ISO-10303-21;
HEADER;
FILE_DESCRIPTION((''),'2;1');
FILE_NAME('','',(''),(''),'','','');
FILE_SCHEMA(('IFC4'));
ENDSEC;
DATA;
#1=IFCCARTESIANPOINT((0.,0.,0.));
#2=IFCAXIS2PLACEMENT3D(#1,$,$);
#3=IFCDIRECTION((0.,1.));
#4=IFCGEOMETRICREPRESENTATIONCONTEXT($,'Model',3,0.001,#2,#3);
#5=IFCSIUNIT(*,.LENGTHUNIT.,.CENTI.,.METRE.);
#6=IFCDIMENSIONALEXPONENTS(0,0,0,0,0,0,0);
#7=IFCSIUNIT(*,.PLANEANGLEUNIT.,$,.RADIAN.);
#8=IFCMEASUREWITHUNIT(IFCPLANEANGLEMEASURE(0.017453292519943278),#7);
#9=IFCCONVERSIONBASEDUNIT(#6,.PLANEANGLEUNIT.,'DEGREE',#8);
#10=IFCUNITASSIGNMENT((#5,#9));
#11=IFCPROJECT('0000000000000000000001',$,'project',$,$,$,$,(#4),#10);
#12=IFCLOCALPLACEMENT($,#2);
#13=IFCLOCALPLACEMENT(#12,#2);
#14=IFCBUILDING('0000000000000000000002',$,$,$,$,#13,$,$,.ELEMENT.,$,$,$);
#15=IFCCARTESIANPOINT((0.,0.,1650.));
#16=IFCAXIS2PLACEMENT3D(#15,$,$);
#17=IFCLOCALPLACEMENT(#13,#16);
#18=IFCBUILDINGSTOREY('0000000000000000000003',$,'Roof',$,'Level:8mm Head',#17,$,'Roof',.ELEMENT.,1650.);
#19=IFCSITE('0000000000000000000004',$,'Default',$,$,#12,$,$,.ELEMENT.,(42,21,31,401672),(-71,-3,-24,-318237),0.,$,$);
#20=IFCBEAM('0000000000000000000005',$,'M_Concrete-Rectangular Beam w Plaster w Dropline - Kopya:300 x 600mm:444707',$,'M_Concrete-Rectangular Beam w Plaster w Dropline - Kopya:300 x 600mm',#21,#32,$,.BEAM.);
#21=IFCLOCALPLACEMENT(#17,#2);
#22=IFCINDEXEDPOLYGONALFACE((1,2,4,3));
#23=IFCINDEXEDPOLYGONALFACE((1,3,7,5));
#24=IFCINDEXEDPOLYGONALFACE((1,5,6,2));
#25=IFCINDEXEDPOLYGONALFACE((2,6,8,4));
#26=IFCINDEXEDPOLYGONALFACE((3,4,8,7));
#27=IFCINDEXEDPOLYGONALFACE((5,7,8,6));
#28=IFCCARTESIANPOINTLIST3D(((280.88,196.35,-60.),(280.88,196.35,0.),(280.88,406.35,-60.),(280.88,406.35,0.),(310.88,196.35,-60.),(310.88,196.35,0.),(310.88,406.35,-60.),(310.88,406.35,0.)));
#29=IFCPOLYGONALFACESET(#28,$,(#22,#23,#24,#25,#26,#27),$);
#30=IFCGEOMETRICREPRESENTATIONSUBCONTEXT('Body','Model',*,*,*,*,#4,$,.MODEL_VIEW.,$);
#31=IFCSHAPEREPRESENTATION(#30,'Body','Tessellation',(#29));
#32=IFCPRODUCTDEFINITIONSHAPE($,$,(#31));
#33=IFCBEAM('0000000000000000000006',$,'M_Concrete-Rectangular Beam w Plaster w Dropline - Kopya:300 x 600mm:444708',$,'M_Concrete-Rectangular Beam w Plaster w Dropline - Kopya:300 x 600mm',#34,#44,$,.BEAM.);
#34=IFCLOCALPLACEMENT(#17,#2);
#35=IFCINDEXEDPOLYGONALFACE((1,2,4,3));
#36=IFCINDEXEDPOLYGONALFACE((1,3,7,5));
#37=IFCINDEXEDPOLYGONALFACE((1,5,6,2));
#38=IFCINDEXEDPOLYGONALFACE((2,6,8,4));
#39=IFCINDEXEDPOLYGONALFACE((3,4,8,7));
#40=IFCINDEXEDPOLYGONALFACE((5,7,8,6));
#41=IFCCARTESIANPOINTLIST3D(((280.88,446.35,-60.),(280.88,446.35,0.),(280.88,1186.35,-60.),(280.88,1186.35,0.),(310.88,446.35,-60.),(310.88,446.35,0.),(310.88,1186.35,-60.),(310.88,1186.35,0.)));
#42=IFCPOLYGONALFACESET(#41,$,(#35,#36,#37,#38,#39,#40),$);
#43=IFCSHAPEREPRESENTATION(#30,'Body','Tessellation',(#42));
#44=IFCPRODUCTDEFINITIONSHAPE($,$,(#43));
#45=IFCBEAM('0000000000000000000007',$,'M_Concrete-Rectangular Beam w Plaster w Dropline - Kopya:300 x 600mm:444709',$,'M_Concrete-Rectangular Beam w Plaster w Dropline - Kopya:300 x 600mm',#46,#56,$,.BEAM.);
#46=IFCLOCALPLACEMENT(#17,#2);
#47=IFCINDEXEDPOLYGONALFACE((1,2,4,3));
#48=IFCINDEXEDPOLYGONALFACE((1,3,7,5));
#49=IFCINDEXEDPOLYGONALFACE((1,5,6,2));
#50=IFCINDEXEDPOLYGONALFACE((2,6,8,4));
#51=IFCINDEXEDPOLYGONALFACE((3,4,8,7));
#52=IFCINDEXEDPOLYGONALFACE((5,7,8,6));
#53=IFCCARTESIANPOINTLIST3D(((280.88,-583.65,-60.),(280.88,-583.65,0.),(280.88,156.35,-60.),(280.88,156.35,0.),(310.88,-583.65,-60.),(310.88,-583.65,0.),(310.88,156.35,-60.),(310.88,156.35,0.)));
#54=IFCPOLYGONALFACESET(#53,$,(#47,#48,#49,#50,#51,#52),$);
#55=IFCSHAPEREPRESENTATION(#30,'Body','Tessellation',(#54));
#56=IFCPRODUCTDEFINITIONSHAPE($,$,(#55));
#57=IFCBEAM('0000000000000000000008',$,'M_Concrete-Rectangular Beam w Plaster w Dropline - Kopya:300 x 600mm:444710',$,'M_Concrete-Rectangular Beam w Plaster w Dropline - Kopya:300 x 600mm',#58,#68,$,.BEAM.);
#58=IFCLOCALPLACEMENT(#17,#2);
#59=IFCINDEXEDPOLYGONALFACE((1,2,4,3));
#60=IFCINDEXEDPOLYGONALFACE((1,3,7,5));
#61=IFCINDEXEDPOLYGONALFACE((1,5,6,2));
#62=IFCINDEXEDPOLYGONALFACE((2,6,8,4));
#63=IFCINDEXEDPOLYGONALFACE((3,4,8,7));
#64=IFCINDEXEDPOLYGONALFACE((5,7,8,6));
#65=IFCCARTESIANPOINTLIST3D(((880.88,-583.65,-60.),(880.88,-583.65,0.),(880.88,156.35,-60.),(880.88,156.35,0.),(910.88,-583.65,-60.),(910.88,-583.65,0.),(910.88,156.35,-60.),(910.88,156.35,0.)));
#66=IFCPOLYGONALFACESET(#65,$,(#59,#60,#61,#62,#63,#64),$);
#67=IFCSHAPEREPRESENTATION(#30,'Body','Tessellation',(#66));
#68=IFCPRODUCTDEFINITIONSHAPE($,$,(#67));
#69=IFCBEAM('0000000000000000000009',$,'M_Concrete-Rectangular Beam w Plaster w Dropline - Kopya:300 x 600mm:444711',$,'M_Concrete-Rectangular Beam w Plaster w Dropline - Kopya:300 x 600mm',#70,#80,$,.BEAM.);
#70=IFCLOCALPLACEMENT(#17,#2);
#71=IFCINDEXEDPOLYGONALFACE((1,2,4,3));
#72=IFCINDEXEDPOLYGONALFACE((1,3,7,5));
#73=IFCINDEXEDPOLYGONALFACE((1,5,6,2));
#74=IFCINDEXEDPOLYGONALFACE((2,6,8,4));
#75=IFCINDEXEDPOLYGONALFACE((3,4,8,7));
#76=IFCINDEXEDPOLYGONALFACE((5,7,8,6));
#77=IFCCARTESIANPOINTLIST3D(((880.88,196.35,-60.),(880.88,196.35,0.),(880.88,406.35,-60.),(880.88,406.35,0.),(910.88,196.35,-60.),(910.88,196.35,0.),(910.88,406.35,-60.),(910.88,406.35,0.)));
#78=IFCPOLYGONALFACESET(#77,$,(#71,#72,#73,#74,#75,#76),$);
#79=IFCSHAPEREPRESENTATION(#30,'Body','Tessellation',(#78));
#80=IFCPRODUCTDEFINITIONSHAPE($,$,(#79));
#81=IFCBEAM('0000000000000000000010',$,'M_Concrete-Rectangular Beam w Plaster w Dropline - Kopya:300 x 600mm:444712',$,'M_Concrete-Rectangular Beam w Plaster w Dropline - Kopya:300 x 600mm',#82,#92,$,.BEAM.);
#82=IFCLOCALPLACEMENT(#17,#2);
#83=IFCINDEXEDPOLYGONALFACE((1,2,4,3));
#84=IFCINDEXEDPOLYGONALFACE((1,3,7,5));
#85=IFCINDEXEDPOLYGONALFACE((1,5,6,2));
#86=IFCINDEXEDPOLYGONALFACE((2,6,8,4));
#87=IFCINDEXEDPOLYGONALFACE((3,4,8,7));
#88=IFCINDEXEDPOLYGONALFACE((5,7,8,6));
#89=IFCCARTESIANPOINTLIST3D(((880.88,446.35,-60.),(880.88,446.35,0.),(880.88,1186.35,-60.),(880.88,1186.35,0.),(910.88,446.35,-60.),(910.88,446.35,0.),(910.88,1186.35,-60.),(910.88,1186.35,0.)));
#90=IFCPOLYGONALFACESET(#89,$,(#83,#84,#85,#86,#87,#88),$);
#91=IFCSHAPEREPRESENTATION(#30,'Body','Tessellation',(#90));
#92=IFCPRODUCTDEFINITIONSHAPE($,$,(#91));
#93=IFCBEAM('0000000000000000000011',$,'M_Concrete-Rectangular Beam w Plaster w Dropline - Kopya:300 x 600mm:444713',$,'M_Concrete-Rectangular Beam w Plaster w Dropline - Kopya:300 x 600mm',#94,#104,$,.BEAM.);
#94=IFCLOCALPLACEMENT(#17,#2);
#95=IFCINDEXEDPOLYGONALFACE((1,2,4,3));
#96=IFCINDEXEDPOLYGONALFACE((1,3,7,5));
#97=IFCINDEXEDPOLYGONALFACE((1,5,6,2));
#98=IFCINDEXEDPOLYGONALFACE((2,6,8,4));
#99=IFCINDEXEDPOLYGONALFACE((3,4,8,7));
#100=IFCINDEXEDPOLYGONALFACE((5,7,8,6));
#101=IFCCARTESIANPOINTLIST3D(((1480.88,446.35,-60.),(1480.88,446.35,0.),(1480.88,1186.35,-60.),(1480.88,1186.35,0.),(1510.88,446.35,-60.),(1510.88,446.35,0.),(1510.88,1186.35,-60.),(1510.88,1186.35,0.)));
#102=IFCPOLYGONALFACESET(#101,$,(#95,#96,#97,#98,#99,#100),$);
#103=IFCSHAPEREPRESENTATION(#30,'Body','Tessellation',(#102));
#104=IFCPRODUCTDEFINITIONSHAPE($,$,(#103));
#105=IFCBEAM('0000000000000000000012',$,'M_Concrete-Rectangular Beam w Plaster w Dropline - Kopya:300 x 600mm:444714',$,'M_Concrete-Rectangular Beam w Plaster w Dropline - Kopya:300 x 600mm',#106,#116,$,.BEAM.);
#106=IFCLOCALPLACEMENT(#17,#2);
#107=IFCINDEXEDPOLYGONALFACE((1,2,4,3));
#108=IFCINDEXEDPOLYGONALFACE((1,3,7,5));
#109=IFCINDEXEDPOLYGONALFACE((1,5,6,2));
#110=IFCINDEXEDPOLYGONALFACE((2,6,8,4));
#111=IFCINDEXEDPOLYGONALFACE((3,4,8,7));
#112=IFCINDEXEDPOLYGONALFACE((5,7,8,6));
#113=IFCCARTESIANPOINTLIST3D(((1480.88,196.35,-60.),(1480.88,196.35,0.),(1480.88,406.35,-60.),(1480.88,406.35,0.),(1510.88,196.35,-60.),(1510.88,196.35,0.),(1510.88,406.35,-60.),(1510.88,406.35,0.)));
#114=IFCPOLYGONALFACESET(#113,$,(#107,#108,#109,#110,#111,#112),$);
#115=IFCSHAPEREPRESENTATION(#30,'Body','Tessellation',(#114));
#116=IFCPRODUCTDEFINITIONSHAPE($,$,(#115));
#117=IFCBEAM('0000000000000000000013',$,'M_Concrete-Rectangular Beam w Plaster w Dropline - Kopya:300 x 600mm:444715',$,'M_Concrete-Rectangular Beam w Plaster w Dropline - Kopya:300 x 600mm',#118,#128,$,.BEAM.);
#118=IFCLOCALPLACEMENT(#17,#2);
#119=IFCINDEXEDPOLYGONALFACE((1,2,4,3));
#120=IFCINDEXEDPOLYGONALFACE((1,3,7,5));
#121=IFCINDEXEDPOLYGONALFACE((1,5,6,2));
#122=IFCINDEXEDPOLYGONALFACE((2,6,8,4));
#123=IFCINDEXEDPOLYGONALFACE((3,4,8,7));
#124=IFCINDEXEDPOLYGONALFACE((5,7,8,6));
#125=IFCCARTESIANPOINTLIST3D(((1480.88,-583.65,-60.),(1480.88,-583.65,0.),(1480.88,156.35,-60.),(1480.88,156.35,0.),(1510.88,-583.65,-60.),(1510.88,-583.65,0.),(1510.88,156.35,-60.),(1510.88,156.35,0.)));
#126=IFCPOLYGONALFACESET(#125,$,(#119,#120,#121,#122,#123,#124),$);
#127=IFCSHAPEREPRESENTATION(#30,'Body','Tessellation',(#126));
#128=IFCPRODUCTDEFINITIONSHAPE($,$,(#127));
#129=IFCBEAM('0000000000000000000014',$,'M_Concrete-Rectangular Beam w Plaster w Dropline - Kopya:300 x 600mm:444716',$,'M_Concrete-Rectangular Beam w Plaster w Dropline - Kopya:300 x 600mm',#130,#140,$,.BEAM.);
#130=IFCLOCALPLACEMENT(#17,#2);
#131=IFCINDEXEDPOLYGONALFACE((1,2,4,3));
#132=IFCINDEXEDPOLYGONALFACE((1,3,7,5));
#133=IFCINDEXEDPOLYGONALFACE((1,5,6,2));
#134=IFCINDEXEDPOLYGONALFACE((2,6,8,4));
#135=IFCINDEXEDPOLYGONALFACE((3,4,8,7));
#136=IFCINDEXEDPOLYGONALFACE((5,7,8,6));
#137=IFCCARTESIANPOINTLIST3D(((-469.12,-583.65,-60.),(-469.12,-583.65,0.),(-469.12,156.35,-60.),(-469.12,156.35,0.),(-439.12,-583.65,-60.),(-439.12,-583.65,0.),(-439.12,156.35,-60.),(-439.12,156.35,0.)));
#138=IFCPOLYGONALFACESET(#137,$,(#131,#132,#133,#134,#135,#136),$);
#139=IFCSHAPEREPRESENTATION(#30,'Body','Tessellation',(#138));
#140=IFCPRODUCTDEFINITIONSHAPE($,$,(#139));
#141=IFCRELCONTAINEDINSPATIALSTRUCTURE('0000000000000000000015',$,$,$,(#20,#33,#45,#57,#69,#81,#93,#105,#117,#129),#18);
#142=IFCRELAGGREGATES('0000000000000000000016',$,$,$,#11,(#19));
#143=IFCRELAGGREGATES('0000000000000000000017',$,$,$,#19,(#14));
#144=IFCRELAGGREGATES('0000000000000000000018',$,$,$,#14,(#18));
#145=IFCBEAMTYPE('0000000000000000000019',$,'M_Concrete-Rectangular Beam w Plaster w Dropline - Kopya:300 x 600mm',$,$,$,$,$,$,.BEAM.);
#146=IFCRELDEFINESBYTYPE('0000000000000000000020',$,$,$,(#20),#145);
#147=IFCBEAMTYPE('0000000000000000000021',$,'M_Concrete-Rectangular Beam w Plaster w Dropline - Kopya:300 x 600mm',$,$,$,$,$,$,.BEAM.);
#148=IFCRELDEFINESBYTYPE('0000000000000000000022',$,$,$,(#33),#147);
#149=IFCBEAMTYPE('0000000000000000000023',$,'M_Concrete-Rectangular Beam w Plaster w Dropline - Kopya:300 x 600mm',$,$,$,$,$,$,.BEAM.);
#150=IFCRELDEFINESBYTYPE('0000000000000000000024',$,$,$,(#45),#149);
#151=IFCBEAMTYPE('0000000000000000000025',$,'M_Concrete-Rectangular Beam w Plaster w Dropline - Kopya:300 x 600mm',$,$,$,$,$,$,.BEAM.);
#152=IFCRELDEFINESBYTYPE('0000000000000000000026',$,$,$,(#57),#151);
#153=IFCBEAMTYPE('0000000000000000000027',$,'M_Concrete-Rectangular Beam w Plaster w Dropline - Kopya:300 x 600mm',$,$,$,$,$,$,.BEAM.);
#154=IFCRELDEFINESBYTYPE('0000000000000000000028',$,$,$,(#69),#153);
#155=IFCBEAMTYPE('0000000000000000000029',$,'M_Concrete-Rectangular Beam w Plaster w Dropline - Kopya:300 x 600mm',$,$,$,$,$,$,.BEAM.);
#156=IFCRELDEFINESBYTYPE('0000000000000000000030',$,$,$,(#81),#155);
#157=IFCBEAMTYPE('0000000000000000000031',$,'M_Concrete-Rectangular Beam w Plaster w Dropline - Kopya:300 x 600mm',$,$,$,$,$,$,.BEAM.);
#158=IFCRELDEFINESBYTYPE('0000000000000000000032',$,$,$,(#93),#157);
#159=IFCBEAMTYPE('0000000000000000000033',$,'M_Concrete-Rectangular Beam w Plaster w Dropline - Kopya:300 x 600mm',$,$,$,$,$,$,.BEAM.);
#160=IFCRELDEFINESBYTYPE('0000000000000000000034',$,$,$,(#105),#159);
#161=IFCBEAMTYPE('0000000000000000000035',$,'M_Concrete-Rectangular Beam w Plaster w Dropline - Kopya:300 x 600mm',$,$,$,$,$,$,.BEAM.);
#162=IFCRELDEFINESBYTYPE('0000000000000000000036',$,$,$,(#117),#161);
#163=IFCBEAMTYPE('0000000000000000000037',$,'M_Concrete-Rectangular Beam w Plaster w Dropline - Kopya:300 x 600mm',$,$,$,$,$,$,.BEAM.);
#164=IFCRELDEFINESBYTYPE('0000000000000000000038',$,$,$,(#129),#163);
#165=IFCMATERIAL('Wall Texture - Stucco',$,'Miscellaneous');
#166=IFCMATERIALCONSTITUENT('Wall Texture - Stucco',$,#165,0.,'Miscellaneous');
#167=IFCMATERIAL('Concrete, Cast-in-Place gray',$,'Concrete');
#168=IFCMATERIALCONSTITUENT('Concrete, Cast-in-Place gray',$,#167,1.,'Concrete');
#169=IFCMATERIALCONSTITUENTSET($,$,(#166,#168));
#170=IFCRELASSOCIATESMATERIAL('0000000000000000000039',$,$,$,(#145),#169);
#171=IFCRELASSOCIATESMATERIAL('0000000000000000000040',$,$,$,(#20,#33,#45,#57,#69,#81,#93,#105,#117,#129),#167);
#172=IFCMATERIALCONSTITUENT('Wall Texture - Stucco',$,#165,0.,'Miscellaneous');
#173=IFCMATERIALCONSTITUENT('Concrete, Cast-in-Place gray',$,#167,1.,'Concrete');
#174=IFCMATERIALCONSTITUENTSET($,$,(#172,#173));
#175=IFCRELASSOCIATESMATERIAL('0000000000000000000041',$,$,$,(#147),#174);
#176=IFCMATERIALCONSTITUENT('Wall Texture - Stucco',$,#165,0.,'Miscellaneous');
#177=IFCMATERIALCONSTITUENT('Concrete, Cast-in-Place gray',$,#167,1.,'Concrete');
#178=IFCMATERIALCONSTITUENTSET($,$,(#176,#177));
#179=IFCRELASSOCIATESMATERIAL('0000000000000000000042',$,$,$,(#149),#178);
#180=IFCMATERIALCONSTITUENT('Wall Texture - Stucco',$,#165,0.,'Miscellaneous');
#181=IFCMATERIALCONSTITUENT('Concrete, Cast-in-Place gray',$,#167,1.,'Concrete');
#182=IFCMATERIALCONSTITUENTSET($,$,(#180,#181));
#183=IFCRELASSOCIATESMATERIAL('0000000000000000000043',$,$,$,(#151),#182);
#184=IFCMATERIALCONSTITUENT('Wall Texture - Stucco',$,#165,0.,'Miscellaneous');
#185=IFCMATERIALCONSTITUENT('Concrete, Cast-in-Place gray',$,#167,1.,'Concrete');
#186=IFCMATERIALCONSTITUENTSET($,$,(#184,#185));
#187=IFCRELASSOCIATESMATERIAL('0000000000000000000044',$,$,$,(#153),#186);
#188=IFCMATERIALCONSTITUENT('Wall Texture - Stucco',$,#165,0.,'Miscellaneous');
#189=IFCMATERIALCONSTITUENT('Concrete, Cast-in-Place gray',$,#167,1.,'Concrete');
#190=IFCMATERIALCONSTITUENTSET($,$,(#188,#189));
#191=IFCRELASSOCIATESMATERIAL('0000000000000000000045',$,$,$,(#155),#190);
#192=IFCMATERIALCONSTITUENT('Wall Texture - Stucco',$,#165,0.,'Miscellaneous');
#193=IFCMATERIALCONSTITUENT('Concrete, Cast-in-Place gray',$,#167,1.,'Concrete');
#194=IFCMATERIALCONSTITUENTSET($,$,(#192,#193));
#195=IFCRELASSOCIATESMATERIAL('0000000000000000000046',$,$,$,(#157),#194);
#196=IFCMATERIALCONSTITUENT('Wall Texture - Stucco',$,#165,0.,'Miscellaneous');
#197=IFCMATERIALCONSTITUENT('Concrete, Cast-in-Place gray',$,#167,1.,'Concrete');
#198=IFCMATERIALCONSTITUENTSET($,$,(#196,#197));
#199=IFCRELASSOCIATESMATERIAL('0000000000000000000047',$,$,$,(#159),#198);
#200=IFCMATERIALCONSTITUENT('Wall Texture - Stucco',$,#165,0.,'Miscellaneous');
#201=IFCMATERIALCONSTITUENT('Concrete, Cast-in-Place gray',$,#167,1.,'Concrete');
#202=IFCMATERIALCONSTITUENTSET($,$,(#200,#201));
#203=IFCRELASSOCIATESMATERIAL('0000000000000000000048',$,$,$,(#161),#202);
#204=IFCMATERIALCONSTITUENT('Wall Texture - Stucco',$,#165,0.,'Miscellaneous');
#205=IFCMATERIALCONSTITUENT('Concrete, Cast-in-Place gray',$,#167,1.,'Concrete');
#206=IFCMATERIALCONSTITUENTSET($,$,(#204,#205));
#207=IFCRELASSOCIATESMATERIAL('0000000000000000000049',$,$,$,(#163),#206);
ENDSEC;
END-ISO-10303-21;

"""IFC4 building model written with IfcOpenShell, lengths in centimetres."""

from ifc_helpers import new_model, entity, si_unit, converted_unit, direction, frame, origin, place, context, subcontext, project, spatial, indexed_curve, outline, extrude, source, transform, mapped, material, constituent, constituent_set, type_object, type_shapes, element, save


model = new_model("IFC4")

# Units and contexts
model_context = context("Model", 3, precision=0.001, world=origin(), true_north=direction((0.0, 1.0)))
body_context = subcontext(model_context, "Body", "Model", "MODEL_VIEW")
ifc_project = project(units=[si_unit("LENGTHUNIT", "METRE", prefix="CENTI"), converted_unit("PLANEANGLEUNIT", "DEGREE", entity("IfcPlaneAngleMeasure", 0.017453292519943278), si_unit("PLANEANGLEUNIT", "RADIAN"), dimensions=[0, 0, 0, 0, 0, 0, 0])], contexts=[model_context])

# Site, building, storey
site_placement = place(None, origin())
site = spatial("IfcSite", under=ifc_project, at=site_placement, Name="Default", CompositionType="ELEMENT", RefLatitude=(42, 21, 31, 401672), RefLongitude=(-71, -3, -24, -318237), RefElevation=0.0)
building_placement = place(site_placement, origin())
building = spatial("IfcBuilding", under=site, at=building_placement, CompositionType="ELEMENT")
storey_placement = place(building_placement, frame((0.0, 0.0, 1650.0)))
storey = spatial("IfcBuildingStorey", under=building, at=storey_placement, Name="Roof", ObjectType="Level:8mm Head", LongName="Roof", CompositionType="ELEMENT", Elevation=1650.0)

# Beams
ifc_material_1 = material(Name="Concrete, Cast-in-Place gray", Category="Concrete")
ifc_material_2 = material(Name="Wall Texture - Stucco", Category="Miscellaneous")
ifc_constituent_1 = constituent(ifc_material_2, Name="Wall Texture - Stucco", Category="Miscellaneous", fraction=0.0)
ifc_constituent_2 = constituent(ifc_material_1, Name="Concrete, Cast-in-Place gray", Category="Concrete", fraction=1.0)
ifc_constituent_set_1 = constituent_set(constituents=[ifc_constituent_1, ifc_constituent_2])
beam_type_1 = type_object("IfcBeamType", Name="M_Concrete-Rectangular Beam w Plaster w Dropline - Kopya:300 x 600mm", PredefinedType="BEAM", material=ifc_constituent_set_1)
shared_shape_1 = source(origin(), body_context, "Body", "SweptSolid", [
    extrude(outline(indexed_curve([(-15.0, -30.0), (15.0, -30.0), (15.0, 30.0), (-15.0, 30.0), (-15.0, -30.0)], self_intersect=False)), frame((295.88, 406.35, 1620.0), z_axis=(0.0, -1.0, 0.0), x_axis=(-1.0, 0.0, 0.0)), (0.0, 0.0, 1.0), 210.0),
])
type_shapes(beam_type_1, [shared_shape_1])
beam_1_placement = place(storey_placement, frame((0.0, 0.0, -1650.0)))
element("IfcBeam", 1, at=beam_1_placement, inside=storey, type_object=beam_type_1, material=ifc_material_1, Name="M_Concrete-Rectangular Beam w Plaster w Dropline - Kopya:300 x 600mm:444707", ObjectType="M_Concrete-Rectangular Beam w Plaster w Dropline - Kopya:300 x 600mm", PredefinedType="BEAM", context=body_context, shape_type="MappedRepresentation", body=[
    mapped(shared_shape_1, transform((0.0, 0.0, 0.0), scale=1.0)),
])
ifc_constituent_3 = constituent(ifc_material_2, Name="Wall Texture - Stucco", Category="Miscellaneous", fraction=0.0)
ifc_constituent_4 = constituent(ifc_material_1, Name="Concrete, Cast-in-Place gray", Category="Concrete", fraction=1.0)
ifc_constituent_set_2 = constituent_set(constituents=[ifc_constituent_3, ifc_constituent_4])
beam_type_2 = type_object("IfcBeamType", Name="M_Concrete-Rectangular Beam w Plaster w Dropline - Kopya:300 x 600mm", PredefinedType="BEAM", material=ifc_constituent_set_2)
shared_shape_2 = source(origin(), body_context, "Body", "SweptSolid", [
    extrude(outline(indexed_curve([(-15.0, -30.0), (15.0, -30.0), (15.0, 30.0), (-15.0, 30.0), (-15.0, -30.0)], self_intersect=False)), frame((295.88, 446.35, 1620.0), z_axis=(0.0, 1.0, 0.0), x_axis=(-1.0, 0.0, 0.0)), (0.0, 0.0, 1.0), 740.0),
])
type_shapes(beam_type_2, [shared_shape_2])
beam_2_placement = place(storey_placement, frame((0.0, 0.0, -1650.0)))
element("IfcBeam", 2, at=beam_2_placement, inside=storey, type_object=beam_type_2, material=ifc_material_1, Name="M_Concrete-Rectangular Beam w Plaster w Dropline - Kopya:300 x 600mm:444708", ObjectType="M_Concrete-Rectangular Beam w Plaster w Dropline - Kopya:300 x 600mm", PredefinedType="BEAM", context=body_context, shape_type="MappedRepresentation", body=[
    mapped(shared_shape_2, transform((0.0, 0.0, 0.0), scale=1.0)),
])
ifc_constituent_5 = constituent(ifc_material_2, Name="Wall Texture - Stucco", Category="Miscellaneous", fraction=0.0)
ifc_constituent_6 = constituent(ifc_material_1, Name="Concrete, Cast-in-Place gray", Category="Concrete", fraction=1.0)
ifc_constituent_set_3 = constituent_set(constituents=[ifc_constituent_5, ifc_constituent_6])
beam_type_3 = type_object("IfcBeamType", Name="M_Concrete-Rectangular Beam w Plaster w Dropline - Kopya:300 x 600mm", PredefinedType="BEAM", material=ifc_constituent_set_3)
shared_shape_3 = source(origin(), body_context, "Body", "SweptSolid", [
    extrude(outline(indexed_curve([(-15.0, -30.0), (15.0, -30.0), (15.0, 30.0), (-15.0, 30.0), (-15.0, -30.0)], self_intersect=False)), frame((295.88, 156.35, 1620.0), z_axis=(0.0, -1.0, 0.0), x_axis=(-1.0, 0.0, 0.0)), (0.0, 0.0, 1.0), 740.0),
])
type_shapes(beam_type_3, [shared_shape_3])
beam_3_placement = place(storey_placement, frame((0.0, 0.0, -1650.0)))
element("IfcBeam", 3, at=beam_3_placement, inside=storey, type_object=beam_type_3, material=ifc_material_1, Name="M_Concrete-Rectangular Beam w Plaster w Dropline - Kopya:300 x 600mm:444709", ObjectType="M_Concrete-Rectangular Beam w Plaster w Dropline - Kopya:300 x 600mm", PredefinedType="BEAM", context=body_context, shape_type="MappedRepresentation", body=[
    mapped(shared_shape_3, transform((0.0, 0.0, 0.0), scale=1.0)),
])
ifc_constituent_7 = constituent(ifc_material_2, Name="Wall Texture - Stucco", Category="Miscellaneous", fraction=0.0)
ifc_constituent_8 = constituent(ifc_material_1, Name="Concrete, Cast-in-Place gray", Category="Concrete", fraction=1.0)
ifc_constituent_set_4 = constituent_set(constituents=[ifc_constituent_7, ifc_constituent_8])
beam_type_4 = type_object("IfcBeamType", Name="M_Concrete-Rectangular Beam w Plaster w Dropline - Kopya:300 x 600mm", PredefinedType="BEAM", material=ifc_constituent_set_4)
shared_shape_4 = source(origin(), body_context, "Body", "SweptSolid", [
    extrude(outline(indexed_curve([(-15.0, -30.0), (15.0, -30.0), (15.0, 30.0), (-15.0, 30.0), (-15.0, -30.0)], self_intersect=False)), frame((895.88, -583.65, 1620.0), z_axis=(0.0, 1.0, 0.0), x_axis=(-1.0, 0.0, 0.0)), (0.0, 0.0, 1.0), 740.0),
])
type_shapes(beam_type_4, [shared_shape_4])
beam_4_placement = place(storey_placement, frame((0.0, 0.0, -1650.0)))
element("IfcBeam", 4, at=beam_4_placement, inside=storey, type_object=beam_type_4, material=ifc_material_1, Name="M_Concrete-Rectangular Beam w Plaster w Dropline - Kopya:300 x 600mm:444710", ObjectType="M_Concrete-Rectangular Beam w Plaster w Dropline - Kopya:300 x 600mm", PredefinedType="BEAM", context=body_context, shape_type="MappedRepresentation", body=[
    mapped(shared_shape_4, transform((0.0, 0.0, 0.0), scale=1.0)),
])
ifc_constituent_9 = constituent(ifc_material_2, Name="Wall Texture - Stucco", Category="Miscellaneous", fraction=0.0)
ifc_constituent_10 = constituent(ifc_material_1, Name="Concrete, Cast-in-Place gray", Category="Concrete", fraction=1.0)
ifc_constituent_set_5 = constituent_set(constituents=[ifc_constituent_9, ifc_constituent_10])
beam_type_5 = type_object("IfcBeamType", Name="M_Concrete-Rectangular Beam w Plaster w Dropline - Kopya:300 x 600mm", PredefinedType="BEAM", material=ifc_constituent_set_5)
shared_shape_5 = source(origin(), body_context, "Body", "SweptSolid", [
    extrude(outline(indexed_curve([(-15.0, -30.0), (15.0, -30.0), (15.0, 30.0), (-15.0, 30.0), (-15.0, -30.0)], self_intersect=False)), frame((895.88, 196.35, 1620.0), z_axis=(0.0, 1.0, 0.0), x_axis=(-1.0, 0.0, 0.0)), (0.0, 0.0, 1.0), 210.0),
])
type_shapes(beam_type_5, [shared_shape_5])
beam_5_placement = place(storey_placement, frame((0.0, 0.0, -1650.0)))
element("IfcBeam", 5, at=beam_5_placement, inside=storey, type_object=beam_type_5, material=ifc_material_1, Name="M_Concrete-Rectangular Beam w Plaster w Dropline - Kopya:300 x 600mm:444711", ObjectType="M_Concrete-Rectangular Beam w Plaster w Dropline - Kopya:300 x 600mm", PredefinedType="BEAM", context=body_context, shape_type="MappedRepresentation", body=[
    mapped(shared_shape_5, transform((0.0, 0.0, 0.0), scale=1.0)),
])
ifc_constituent_11 = constituent(ifc_material_2, Name="Wall Texture - Stucco", Category="Miscellaneous", fraction=0.0)
ifc_constituent_12 = constituent(ifc_material_1, Name="Concrete, Cast-in-Place gray", Category="Concrete", fraction=1.0)
ifc_constituent_set_6 = constituent_set(constituents=[ifc_constituent_11, ifc_constituent_12])
beam_type_6 = type_object("IfcBeamType", Name="M_Concrete-Rectangular Beam w Plaster w Dropline - Kopya:300 x 600mm", PredefinedType="BEAM", material=ifc_constituent_set_6)
shared_shape_6 = source(origin(), body_context, "Body", "SweptSolid", [
    extrude(outline(indexed_curve([(-15.0, -30.0), (15.0, -30.0), (15.0, 30.0), (-15.0, 30.0), (-15.0, -30.0)], self_intersect=False)), frame((895.88, 446.35, 1620.0), z_axis=(0.0, 1.0, 0.0), x_axis=(-1.0, 0.0, 0.0)), (0.0, 0.0, 1.0), 740.0),
])
type_shapes(beam_type_6, [shared_shape_6])
beam_6_placement = place(storey_placement, frame((0.0, 0.0, -1650.0)))
element("IfcBeam", 6, at=beam_6_placement, inside=storey, type_object=beam_type_6, material=ifc_material_1, Name="M_Concrete-Rectangular Beam w Plaster w Dropline - Kopya:300 x 600mm:444712", ObjectType="M_Concrete-Rectangular Beam w Plaster w Dropline - Kopya:300 x 600mm", PredefinedType="BEAM", context=body_context, shape_type="MappedRepresentation", body=[
    mapped(shared_shape_6, transform((0.0, 0.0, 0.0), scale=1.0)),
])
ifc_constituent_13 = constituent(ifc_material_2, Name="Wall Texture - Stucco", Category="Miscellaneous", fraction=0.0)
ifc_constituent_14 = constituent(ifc_material_1, Name="Concrete, Cast-in-Place gray", Category="Concrete", fraction=1.0)
ifc_constituent_set_7 = constituent_set(constituents=[ifc_constituent_13, ifc_constituent_14])
beam_type_7 = type_object("IfcBeamType", Name="M_Concrete-Rectangular Beam w Plaster w Dropline - Kopya:300 x 600mm", PredefinedType="BEAM", material=ifc_constituent_set_7)
shared_shape_7 = source(origin(), body_context, "Body", "SweptSolid", [
    extrude(outline(indexed_curve([(-15.0, -30.0), (15.0, -30.0), (15.0, 30.0), (-15.0, 30.0), (-15.0, -30.0)], self_intersect=False)), frame((1495.88, 1186.35, 1620.0), z_axis=(0.0, -1.0, 0.0), x_axis=(-1.0, 0.0, 0.0)), (0.0, 0.0, 1.0), 740.0),
])
type_shapes(beam_type_7, [shared_shape_7])
beam_7_placement = place(storey_placement, frame((0.0, 0.0, -1650.0)))
element("IfcBeam", 7, at=beam_7_placement, inside=storey, type_object=beam_type_7, material=ifc_material_1, Name="M_Concrete-Rectangular Beam w Plaster w Dropline - Kopya:300 x 600mm:444713", ObjectType="M_Concrete-Rectangular Beam w Plaster w Dropline - Kopya:300 x 600mm", PredefinedType="BEAM", context=body_context, shape_type="MappedRepresentation", body=[
    mapped(shared_shape_7, transform((0.0, 0.0, 0.0), scale=1.0)),
])
ifc_constituent_15 = constituent(ifc_material_2, Name="Wall Texture - Stucco", Category="Miscellaneous", fraction=0.0)
ifc_constituent_16 = constituent(ifc_material_1, Name="Concrete, Cast-in-Place gray", Category="Concrete", fraction=1.0)
ifc_constituent_set_8 = constituent_set(constituents=[ifc_constituent_15, ifc_constituent_16])
beam_type_8 = type_object("IfcBeamType", Name="M_Concrete-Rectangular Beam w Plaster w Dropline - Kopya:300 x 600mm", PredefinedType="BEAM", material=ifc_constituent_set_8)
shared_shape_8 = source(origin(), body_context, "Body", "SweptSolid", [
    extrude(outline(indexed_curve([(-15.0, -30.0), (15.0, -30.0), (15.0, 30.0), (-15.0, 30.0), (-15.0, -30.0)], self_intersect=False)), frame((1495.88, 406.35, 1620.0), z_axis=(0.0, -1.0, 0.0), x_axis=(-1.0, 0.0, 0.0)), (0.0, 0.0, 1.0), 210.0),
])
type_shapes(beam_type_8, [shared_shape_8])
beam_8_placement = place(storey_placement, frame((0.0, 0.0, -1650.0)))
element("IfcBeam", 8, at=beam_8_placement, inside=storey, type_object=beam_type_8, material=ifc_material_1, Name="M_Concrete-Rectangular Beam w Plaster w Dropline - Kopya:300 x 600mm:444714", ObjectType="M_Concrete-Rectangular Beam w Plaster w Dropline - Kopya:300 x 600mm", PredefinedType="BEAM", context=body_context, shape_type="MappedRepresentation", body=[
    mapped(shared_shape_8, transform((0.0, 0.0, 0.0), scale=1.0)),
])
ifc_constituent_17 = constituent(ifc_material_2, Name="Wall Texture - Stucco", Category="Miscellaneous", fraction=0.0)
ifc_constituent_18 = constituent(ifc_material_1, Name="Concrete, Cast-in-Place gray", Category="Concrete", fraction=1.0)
ifc_constituent_set_9 = constituent_set(constituents=[ifc_constituent_17, ifc_constituent_18])
beam_type_9 = type_object("IfcBeamType", Name="M_Concrete-Rectangular Beam w Plaster w Dropline - Kopya:300 x 600mm", PredefinedType="BEAM", material=ifc_constituent_set_9)
shared_shape_9 = source(origin(), body_context, "Body", "SweptSolid", [
    extrude(outline(indexed_curve([(-15.0, -30.0), (15.0, -30.0), (15.0, 30.0), (-15.0, 30.0), (-15.0, -30.0)], self_intersect=False)), frame((1495.88, 156.35, 1620.0), z_axis=(0.0, -1.0, 0.0), x_axis=(-1.0, 0.0, 0.0)), (0.0, 0.0, 1.0), 740.0),
])
type_shapes(beam_type_9, [shared_shape_9])
beam_9_placement = place(storey_placement, frame((0.0, 0.0, -1650.0)))
element("IfcBeam", 9, at=beam_9_placement, inside=storey, type_object=beam_type_9, material=ifc_material_1, Name="M_Concrete-Rectangular Beam w Plaster w Dropline - Kopya:300 x 600mm:444715", ObjectType="M_Concrete-Rectangular Beam w Plaster w Dropline - Kopya:300 x 600mm", PredefinedType="BEAM", context=body_context, shape_type="MappedRepresentation", body=[
    mapped(shared_shape_9, transform((0.0, 0.0, 0.0), scale=1.0)),
])
ifc_constituent_19 = constituent(ifc_material_2, Name="Wall Texture - Stucco", Category="Miscellaneous", fraction=0.0)
ifc_constituent_20 = constituent(ifc_material_1, Name="Concrete, Cast-in-Place gray", Category="Concrete", fraction=1.0)
ifc_constituent_set_10 = constituent_set(constituents=[ifc_constituent_19, ifc_constituent_20])
beam_type_10 = type_object("IfcBeamType", Name="M_Concrete-Rectangular Beam w Plaster w Dropline - Kopya:300 x 600mm", PredefinedType="BEAM", material=ifc_constituent_set_10)
shared_shape_10 = source(origin(), body_context, "Body", "SweptSolid", [
    extrude(outline(indexed_curve([(-15.0, -30.0), (15.0, -30.0), (15.0, 30.0), (-15.0, 30.0), (-15.0, -30.0)], self_intersect=False)), frame((-454.12, -583.65, 1620.0), z_axis=(0.0, 1.0, 0.0), x_axis=(-1.0, 0.0, 0.0)), (0.0, 0.0, 1.0), 740.0),
])
type_shapes(beam_type_10, [shared_shape_10])
beam_10_placement = place(storey_placement, frame((0.0, 0.0, -1650.0)))
element("IfcBeam", 10, at=beam_10_placement, inside=storey, type_object=beam_type_10, material=ifc_material_1, Name="M_Concrete-Rectangular Beam w Plaster w Dropline - Kopya:300 x 600mm:444716", ObjectType="M_Concrete-Rectangular Beam w Plaster w Dropline - Kopya:300 x 600mm", PredefinedType="BEAM", context=body_context, shape_type="MappedRepresentation", body=[
    mapped(shared_shape_10, transform((0.0, 0.0, 0.0), scale=1.0)),
])

save(model, "model.ifc")
